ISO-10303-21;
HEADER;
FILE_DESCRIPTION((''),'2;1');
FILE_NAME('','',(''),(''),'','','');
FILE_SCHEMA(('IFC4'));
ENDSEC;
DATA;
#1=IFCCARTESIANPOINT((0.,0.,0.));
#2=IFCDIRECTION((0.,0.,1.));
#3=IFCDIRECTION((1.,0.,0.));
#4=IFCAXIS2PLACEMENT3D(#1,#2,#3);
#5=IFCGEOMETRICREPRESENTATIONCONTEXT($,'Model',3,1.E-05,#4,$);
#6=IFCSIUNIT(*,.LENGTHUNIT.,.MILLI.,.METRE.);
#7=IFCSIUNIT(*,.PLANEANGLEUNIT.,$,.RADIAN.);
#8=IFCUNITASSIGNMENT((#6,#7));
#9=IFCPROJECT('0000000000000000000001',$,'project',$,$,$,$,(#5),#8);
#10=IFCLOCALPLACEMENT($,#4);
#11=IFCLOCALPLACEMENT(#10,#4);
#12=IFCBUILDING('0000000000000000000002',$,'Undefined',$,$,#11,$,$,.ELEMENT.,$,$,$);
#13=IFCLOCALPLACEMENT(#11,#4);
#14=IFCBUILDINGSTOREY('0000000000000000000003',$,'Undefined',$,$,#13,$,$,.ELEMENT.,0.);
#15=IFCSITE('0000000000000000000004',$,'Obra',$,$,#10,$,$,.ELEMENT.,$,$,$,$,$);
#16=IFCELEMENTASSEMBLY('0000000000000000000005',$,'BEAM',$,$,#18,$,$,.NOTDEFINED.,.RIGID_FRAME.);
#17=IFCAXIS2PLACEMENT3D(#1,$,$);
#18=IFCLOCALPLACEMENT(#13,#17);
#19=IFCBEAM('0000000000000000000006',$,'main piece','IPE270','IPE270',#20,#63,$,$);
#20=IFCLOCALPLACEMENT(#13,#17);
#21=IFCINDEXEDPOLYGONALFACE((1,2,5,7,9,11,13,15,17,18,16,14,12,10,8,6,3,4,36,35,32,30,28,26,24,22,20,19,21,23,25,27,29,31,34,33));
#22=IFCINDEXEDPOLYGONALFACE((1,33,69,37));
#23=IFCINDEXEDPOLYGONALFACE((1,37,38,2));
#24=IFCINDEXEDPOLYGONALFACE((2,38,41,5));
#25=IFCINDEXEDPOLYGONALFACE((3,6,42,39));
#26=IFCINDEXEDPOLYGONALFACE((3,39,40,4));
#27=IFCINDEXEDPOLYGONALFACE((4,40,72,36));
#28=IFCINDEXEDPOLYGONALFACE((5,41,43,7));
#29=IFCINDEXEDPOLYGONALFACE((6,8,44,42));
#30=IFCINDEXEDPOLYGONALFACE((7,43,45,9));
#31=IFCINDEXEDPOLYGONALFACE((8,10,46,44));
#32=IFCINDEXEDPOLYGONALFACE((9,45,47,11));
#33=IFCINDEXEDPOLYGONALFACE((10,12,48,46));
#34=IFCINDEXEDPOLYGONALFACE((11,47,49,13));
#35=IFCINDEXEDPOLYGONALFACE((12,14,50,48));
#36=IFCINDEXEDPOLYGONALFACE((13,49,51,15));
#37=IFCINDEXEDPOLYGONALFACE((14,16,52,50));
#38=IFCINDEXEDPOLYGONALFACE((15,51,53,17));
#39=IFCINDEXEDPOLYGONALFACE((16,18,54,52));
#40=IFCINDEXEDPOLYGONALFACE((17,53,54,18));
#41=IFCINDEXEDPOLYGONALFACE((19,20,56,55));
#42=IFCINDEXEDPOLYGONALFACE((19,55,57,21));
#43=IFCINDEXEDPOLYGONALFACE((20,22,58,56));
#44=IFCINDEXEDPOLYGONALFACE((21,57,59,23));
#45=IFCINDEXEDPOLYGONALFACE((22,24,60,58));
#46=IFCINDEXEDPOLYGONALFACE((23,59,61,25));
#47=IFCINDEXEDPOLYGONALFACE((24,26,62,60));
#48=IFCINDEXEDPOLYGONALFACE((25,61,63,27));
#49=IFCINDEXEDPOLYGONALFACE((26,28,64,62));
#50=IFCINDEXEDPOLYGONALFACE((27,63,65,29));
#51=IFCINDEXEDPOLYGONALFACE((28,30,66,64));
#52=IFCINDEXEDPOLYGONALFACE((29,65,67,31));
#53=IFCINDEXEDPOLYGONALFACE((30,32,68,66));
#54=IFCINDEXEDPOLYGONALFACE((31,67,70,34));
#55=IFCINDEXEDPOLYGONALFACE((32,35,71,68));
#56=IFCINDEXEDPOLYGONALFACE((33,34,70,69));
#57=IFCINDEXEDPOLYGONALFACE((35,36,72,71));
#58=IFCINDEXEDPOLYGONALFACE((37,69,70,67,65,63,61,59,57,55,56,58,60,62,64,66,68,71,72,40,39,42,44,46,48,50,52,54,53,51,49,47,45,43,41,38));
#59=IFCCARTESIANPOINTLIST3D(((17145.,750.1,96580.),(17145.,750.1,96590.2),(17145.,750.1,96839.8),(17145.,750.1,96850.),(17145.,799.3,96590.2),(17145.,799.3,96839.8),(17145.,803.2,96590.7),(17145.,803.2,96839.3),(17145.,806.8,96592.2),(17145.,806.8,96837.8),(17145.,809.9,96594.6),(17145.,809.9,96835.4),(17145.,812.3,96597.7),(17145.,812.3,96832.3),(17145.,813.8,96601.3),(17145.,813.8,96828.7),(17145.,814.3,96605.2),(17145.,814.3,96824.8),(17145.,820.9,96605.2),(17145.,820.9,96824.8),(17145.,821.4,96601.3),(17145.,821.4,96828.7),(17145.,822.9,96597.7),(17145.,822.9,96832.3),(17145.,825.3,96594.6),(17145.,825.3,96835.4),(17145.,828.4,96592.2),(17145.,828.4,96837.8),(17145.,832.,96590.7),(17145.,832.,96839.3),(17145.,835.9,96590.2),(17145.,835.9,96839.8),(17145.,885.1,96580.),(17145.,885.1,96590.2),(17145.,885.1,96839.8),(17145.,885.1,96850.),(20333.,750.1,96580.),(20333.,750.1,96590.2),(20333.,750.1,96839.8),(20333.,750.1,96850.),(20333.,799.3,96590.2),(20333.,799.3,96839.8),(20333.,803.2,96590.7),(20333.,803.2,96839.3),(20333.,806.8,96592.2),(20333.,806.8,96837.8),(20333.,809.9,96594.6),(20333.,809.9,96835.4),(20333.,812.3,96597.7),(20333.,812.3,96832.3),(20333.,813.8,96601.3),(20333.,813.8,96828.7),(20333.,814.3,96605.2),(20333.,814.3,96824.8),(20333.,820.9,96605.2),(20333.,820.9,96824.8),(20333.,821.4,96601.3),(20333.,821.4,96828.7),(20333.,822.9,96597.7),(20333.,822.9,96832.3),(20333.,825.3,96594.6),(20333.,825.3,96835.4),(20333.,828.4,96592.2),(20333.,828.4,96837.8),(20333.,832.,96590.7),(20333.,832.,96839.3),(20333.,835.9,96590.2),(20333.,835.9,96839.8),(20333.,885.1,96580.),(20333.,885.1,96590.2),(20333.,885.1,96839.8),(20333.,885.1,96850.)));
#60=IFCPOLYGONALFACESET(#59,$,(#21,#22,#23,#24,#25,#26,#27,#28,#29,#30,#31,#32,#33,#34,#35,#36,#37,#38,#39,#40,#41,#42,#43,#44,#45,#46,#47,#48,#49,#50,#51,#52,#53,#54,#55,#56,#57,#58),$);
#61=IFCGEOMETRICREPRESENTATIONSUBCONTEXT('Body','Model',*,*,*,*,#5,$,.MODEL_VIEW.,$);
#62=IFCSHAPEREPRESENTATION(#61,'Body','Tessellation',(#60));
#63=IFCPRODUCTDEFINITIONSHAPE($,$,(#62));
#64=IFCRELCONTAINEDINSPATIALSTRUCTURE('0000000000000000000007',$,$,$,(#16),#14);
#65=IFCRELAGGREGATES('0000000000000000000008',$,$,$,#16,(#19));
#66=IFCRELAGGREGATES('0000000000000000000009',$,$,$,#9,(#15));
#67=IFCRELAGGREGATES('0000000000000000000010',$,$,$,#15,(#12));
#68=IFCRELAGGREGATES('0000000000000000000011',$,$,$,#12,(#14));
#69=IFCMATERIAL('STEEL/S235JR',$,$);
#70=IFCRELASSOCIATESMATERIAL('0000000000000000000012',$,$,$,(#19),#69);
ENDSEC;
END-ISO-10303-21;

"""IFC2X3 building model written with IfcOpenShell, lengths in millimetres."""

from ifc_helpers import new_model, si_unit, frame, origin_with_axes, origin_2d_with_axis, place, context, subcontext, project, spatial, i_section, extrude, material, element, aggregate, save


model = new_model("IFC2X3")

# Units and contexts
model_context = context("Model", 3, precision=1e-05, world=origin_with_axes())
body_context = subcontext(model_context, "Body", "Model", "MODEL_VIEW")
ifc_project = project(units=[si_unit("LENGTHUNIT", "METRE", prefix="MILLI"), si_unit("PLANEANGLEUNIT", "RADIAN")], contexts=[model_context])

# Site, building, storey
site_placement = place(None, origin_with_axes())
site = spatial("IfcSite", under=ifc_project, at=site_placement, Name="Obra", CompositionType="ELEMENT")
building_placement = place(site_placement, origin_with_axes())
building = spatial("IfcBuilding", under=site, at=building_placement, Name="Undefined", CompositionType="ELEMENT")
storey_placement = place(building_placement, origin_with_axes())
storey = spatial("IfcBuildingStorey", under=building, at=storey_placement, Name="Undefined", CompositionType="ELEMENT", Elevation=0.0)

# Shared definitions
ifc_material = material(Name="STEEL/S235JR")

# Element assembly, beam
assembly_1_placement = place(storey_placement, origin_with_axes())
assembly_1 = element("IfcElementAssembly", 1, at=assembly_1_placement, inside=storey, Name="BEAM", AssemblyPlace="NOTDEFINED", PredefinedType="RIGID_FRAME")
beam_1_placement = place(assembly_1_placement, frame((17145.0, 817.6, 96715.0), z_axis=(0.0, 0.0, 1.0), x_axis=(1.0, 0.0, 0.0)))
beam_1 = element("IfcBeam", 2, at=beam_1_placement, material=ifc_material, Name="main piece", Description="IPE270", ObjectType="IPE270", context=body_context, shape_type="SweptSolid", body=[
    extrude(i_section(OverallWidth=135.0, OverallDepth=270.0, WebThickness=6.6, FlangeThickness=10.2, FilletRadius=15.0, at=origin_2d_with_axis()), frame((3188.0, 0.0, 0.0), z_axis=(-1.0, 0.0, 0.0), x_axis=(0.0, -1.0, 0.0)), (0.0, 0.0, 1.0), 3188.0),
])
aggregate(assembly_1, [beam_1])

save(model, "model.ifc")
